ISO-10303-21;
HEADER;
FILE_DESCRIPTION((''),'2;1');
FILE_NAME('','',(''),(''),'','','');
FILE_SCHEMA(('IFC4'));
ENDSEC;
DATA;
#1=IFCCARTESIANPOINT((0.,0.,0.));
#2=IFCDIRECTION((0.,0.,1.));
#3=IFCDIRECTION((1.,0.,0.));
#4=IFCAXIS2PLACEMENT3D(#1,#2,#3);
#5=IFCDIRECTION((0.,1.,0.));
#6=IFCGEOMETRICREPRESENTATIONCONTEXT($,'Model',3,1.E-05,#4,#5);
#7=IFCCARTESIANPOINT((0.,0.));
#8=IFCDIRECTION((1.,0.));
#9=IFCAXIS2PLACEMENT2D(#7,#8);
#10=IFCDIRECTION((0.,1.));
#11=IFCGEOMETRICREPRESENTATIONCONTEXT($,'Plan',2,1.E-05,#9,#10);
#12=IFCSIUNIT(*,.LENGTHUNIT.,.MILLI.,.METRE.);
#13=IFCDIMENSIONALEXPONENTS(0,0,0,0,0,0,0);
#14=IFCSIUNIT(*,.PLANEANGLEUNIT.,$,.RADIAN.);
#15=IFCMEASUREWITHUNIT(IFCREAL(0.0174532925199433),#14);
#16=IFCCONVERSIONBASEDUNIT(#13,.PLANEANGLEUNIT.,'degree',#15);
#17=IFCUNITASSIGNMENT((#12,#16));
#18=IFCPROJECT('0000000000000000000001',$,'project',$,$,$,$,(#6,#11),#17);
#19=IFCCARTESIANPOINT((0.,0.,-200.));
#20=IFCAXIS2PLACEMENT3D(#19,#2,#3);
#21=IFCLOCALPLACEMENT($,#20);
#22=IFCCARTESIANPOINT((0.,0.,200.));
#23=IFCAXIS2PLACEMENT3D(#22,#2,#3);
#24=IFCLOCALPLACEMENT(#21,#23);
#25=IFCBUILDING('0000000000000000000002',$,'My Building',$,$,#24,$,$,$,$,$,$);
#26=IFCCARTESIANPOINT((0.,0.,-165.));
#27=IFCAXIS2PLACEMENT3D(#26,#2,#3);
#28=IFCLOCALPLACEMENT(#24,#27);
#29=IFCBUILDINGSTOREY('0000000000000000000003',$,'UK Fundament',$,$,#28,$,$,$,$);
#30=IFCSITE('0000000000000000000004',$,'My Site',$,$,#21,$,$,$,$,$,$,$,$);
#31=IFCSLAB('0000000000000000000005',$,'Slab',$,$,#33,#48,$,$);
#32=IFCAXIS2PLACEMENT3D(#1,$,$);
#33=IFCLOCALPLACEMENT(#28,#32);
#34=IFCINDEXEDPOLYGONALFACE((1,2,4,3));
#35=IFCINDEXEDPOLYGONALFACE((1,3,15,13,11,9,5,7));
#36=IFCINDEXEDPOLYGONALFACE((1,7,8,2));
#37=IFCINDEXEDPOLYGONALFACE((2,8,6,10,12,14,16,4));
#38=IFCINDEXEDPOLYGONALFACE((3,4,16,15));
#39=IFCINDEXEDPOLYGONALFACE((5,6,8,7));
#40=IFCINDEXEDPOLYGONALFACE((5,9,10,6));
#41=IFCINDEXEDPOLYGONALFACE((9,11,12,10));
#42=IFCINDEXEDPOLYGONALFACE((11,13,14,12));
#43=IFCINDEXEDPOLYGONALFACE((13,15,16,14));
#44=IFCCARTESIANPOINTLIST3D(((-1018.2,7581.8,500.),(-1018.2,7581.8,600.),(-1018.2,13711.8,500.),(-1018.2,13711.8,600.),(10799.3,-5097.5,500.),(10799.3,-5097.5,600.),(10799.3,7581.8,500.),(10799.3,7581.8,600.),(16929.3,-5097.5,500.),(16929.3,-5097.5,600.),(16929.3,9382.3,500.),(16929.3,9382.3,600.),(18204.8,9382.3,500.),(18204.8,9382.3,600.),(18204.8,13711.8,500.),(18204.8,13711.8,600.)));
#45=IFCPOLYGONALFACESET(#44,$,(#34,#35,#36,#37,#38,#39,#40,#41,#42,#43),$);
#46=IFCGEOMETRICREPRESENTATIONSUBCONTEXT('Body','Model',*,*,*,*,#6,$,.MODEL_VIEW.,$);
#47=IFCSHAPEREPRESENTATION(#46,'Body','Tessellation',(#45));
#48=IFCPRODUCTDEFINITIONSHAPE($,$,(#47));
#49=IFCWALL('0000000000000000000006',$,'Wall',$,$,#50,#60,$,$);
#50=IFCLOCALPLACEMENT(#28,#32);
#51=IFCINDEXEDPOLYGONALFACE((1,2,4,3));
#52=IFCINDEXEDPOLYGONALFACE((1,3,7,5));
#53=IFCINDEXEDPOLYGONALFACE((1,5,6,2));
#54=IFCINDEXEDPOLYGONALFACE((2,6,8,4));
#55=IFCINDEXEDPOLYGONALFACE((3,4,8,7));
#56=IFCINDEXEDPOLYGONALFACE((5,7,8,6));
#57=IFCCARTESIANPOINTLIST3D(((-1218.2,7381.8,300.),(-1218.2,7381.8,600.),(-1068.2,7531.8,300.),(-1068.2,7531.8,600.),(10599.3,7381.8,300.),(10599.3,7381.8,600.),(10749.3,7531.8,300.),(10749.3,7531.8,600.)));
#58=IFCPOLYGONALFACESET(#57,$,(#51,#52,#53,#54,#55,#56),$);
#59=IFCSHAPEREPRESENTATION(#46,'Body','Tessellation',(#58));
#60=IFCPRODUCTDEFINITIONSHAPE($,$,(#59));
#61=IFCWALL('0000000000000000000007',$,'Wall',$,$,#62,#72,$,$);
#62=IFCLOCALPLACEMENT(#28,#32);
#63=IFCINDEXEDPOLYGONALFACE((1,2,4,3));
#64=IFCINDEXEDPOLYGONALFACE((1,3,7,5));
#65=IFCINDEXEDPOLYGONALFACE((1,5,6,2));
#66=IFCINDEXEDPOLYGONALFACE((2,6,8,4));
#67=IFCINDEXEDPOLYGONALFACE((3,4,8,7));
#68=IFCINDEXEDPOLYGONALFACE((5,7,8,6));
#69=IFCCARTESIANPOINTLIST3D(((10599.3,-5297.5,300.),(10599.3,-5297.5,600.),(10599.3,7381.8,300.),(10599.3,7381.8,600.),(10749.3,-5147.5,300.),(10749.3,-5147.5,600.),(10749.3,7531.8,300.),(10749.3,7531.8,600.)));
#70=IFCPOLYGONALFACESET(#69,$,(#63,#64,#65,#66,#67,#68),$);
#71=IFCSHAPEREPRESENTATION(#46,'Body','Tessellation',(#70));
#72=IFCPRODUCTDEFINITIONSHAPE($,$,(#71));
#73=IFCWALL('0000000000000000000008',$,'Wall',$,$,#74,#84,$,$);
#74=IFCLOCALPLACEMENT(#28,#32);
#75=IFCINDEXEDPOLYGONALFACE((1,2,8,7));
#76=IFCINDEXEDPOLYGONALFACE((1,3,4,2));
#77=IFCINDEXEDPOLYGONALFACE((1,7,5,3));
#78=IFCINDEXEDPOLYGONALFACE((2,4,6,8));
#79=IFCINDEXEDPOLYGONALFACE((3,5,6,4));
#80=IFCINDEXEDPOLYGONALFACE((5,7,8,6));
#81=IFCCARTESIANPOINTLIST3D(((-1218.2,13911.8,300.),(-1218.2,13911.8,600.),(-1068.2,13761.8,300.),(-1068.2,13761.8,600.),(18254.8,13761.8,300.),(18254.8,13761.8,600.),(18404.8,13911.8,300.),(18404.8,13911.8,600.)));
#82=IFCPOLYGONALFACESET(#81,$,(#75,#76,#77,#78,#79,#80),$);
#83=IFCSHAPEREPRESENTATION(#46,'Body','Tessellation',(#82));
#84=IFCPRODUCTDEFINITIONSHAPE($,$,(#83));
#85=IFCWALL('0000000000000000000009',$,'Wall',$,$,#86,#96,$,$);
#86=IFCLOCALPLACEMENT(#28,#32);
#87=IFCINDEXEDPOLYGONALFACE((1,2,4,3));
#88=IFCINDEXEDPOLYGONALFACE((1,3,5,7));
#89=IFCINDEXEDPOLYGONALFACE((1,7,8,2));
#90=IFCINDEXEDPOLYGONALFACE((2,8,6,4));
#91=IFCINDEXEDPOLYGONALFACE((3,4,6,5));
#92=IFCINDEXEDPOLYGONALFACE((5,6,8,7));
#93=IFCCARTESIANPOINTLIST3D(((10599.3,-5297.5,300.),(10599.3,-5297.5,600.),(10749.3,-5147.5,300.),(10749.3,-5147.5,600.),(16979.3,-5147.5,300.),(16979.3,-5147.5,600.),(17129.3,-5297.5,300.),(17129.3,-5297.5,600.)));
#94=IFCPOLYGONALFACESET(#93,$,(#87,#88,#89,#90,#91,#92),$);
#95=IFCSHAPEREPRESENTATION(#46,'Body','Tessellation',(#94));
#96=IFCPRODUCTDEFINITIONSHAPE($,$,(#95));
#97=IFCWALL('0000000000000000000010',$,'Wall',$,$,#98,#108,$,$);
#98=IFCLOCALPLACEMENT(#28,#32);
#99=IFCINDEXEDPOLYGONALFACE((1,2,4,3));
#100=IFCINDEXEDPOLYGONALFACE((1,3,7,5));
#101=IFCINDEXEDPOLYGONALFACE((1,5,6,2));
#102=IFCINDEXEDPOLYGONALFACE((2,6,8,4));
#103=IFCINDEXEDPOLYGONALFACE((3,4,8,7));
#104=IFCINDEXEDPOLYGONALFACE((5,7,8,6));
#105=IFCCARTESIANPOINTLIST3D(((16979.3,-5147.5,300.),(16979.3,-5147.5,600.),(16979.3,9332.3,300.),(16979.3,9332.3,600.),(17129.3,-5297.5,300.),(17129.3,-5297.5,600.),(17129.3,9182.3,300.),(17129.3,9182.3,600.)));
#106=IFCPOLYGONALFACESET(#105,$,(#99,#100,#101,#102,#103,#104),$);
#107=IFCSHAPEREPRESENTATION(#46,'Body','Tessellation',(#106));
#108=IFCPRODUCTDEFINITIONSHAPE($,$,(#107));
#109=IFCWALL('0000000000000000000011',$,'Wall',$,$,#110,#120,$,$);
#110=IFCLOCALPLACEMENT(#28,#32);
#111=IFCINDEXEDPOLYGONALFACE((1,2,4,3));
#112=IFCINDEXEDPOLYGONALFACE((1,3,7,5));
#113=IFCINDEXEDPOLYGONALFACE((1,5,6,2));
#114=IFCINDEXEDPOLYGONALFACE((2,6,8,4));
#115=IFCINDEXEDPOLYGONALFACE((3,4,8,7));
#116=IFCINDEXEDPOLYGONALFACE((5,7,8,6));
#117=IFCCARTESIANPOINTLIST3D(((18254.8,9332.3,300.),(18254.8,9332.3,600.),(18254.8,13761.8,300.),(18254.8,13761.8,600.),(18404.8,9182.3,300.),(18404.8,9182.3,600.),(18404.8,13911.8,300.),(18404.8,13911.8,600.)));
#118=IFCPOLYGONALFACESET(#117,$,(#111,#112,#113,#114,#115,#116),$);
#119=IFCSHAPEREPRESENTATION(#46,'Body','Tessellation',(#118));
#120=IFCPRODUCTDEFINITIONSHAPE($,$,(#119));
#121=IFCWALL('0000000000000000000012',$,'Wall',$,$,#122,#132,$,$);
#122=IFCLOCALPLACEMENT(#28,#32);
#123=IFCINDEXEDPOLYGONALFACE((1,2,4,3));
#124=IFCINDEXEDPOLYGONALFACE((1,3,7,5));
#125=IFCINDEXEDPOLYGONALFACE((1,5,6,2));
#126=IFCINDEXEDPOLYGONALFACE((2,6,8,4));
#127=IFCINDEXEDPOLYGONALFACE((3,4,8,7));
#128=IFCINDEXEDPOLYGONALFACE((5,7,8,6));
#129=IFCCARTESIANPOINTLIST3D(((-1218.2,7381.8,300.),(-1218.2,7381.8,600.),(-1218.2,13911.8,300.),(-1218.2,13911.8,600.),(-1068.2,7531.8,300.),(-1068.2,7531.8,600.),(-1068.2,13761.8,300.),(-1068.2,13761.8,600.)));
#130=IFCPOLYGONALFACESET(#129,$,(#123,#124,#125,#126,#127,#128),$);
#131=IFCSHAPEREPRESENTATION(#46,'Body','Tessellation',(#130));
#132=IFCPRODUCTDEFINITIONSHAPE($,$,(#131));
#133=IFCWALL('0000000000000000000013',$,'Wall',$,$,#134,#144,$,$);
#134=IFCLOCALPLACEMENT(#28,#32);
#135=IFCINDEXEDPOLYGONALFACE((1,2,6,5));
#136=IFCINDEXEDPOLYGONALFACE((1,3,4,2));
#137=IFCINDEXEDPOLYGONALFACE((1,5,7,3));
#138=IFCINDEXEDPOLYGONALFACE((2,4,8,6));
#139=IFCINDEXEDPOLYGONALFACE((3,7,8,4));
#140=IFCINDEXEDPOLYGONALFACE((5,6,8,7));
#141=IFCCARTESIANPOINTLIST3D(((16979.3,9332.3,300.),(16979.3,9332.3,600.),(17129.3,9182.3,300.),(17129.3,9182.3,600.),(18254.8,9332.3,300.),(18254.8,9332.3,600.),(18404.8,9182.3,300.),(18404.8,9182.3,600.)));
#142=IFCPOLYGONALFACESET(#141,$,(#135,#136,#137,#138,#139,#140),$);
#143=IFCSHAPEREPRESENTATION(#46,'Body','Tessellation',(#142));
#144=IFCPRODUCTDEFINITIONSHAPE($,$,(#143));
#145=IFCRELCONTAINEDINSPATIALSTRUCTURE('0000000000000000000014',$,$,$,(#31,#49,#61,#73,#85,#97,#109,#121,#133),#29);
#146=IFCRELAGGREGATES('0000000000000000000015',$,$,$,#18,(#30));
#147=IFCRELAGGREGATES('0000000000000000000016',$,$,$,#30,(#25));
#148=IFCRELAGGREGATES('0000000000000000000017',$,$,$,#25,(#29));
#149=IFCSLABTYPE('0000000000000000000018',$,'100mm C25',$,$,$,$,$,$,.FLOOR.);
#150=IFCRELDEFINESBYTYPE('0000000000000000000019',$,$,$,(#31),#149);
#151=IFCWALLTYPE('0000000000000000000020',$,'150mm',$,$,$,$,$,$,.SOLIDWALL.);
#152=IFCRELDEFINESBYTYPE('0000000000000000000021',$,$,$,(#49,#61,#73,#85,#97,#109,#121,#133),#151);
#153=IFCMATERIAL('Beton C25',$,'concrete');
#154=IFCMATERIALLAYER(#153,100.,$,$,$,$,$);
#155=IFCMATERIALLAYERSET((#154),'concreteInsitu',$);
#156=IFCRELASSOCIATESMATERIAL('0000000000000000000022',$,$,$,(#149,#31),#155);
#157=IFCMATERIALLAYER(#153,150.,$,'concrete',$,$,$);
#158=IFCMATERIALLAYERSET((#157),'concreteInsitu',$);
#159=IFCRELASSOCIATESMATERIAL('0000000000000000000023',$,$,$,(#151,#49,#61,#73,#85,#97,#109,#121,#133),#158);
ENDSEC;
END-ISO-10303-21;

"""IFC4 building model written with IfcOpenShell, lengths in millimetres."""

from ifc_helpers import new_model, entity, si_unit, converted_unit, direction, frame, origin_with_axes, origin_2d_with_axis, place, context, subcontext, project, spatial, line, indexed_curve, outline, extrude, clip, halfspace, material, layer, layer_set, layer_usage, type_object, element, save


model = new_model("IFC4")

# Units and contexts
model_context = context("Model", 3, precision=1e-05, world=origin_with_axes(), true_north=direction((0.0, 1.0, 0.0)))
plan_context = context("Plan", 2, precision=1e-05, world=origin_2d_with_axis(), true_north=direction((0.0, 1.0)))
body_context = subcontext(model_context, "Body", "Model", "MODEL_VIEW")
ifc_project = project(units=[si_unit("LENGTHUNIT", "METRE", prefix="MILLI"), converted_unit("PLANEANGLEUNIT", "degree", entity("IfcReal", 0.0174532925199433), si_unit("PLANEANGLEUNIT", "RADIAN"), dimensions=[0, 0, 0, 0, 0, 0, 0])], contexts=[model_context, plan_context])

# Site, building, storey
site_placement = place(None, frame((0.0, 0.0, -200.0), z_axis=(0.0, 0.0, 1.0), x_axis=(1.0, 0.0, 0.0)))
site = spatial("IfcSite", under=ifc_project, at=site_placement, Name="My Site")
building_placement = place(site_placement, frame((0.0, 0.0, 200.0), z_axis=(0.0, 0.0, 1.0), x_axis=(1.0, 0.0, 0.0)))
building = spatial("IfcBuilding", under=site, at=building_placement, Name="My Building")
storey_placement = place(building_placement, frame((0.0, 0.0, -165.0), z_axis=(0.0, 0.0, 1.0), x_axis=(1.0, 0.0, 0.0)))
storey = spatial("IfcBuildingStorey", under=building, at=storey_placement, Name="UK Fundament")

# Slab
ifc_material = material(Name="Beton C25", Category="concrete")
ifc_layer_1 = layer(ifc_material, 100.0)
ifc_layer_set_1 = layer_set([ifc_layer_1], Name="concreteInsitu")
ifc_layer_usage_1 = layer_usage(ifc_layer_set_1, "AXIS3", "POSITIVE", 0.0)
slab_type = type_object("IfcSlabType", Name="100mm C25", PredefinedType="FLOOR", material=ifc_layer_set_1)
slab_placement = place(storey_placement, frame((-1018.2, 7581.8, 500.0), z_axis=(0.0, 0.0, 1.0), x_axis=(1.0, 0.0, 0.0)))
element("IfcSlab", 1, at=slab_placement, inside=storey, type_object=slab_type, material=ifc_layer_usage_1, Name="Slab", context=body_context, shape_type="SweptSolid", body=[
    extrude(outline(indexed_curve([(17947.4, 1800.5), (19222.9, 1800.5), (19222.9, 6130.0), (0.0, 6130.0), (0.0, 0.0), (11817.4, 0.0), (11817.4, -12679.3), (17947.4, -12679.3)], segments=[line(5, 4), line(4, 3), line(3, 2), line(2, 1), line(1, 8), line(8, 7), line(7, 6), line(6, 5)], self_intersect=False)), None, (0.0, 0.0, 1.0), 100.0),
])

# Walls
ifc_layer_2 = layer(ifc_material, 150.0, Name="concrete")
ifc_layer_set_2 = layer_set([ifc_layer_2], Name="concreteInsitu")
ifc_layer_usage_2 = layer_usage(ifc_layer_set_2, "AXIS2", "POSITIVE", 0.0)
wall_type = type_object("IfcWallType", Name="150mm", PredefinedType="SOLIDWALL", material=ifc_layer_set_2)
wall_1_placement = place(storey_placement, frame((-1218.2, 7381.8, 300.0), z_axis=(0.0, 0.0, 1.0), x_axis=(1.0, 0.0, 0.0)))
element("IfcWall", 2, at=wall_1_placement, inside=storey, type_object=wall_type, material=ifc_layer_usage_2, Name="Wall", context=body_context, shape_type="Clipping", body=[
    clip(clip(extrude(outline(indexed_curve([(0.0, 0.0), (0.0, 150.0), (11967.4, 150.0), (11967.4, 0.0), (0.0, 0.0)], self_intersect=False)), origin_with_axes(), (0.0, 0.0, 1.0), 300.0), halfspace(frame((0.0, 0.0, -135.0), z_axis=(-0.707107, 0.707107, 0.0), x_axis=(0.707107, 0.707107, 0.0)), False)), halfspace(frame((11817.4, 0.0, -135.0), z_axis=(0.707108, -0.707106, 0.0), x_axis=(-0.707106, -0.707108, 0.0)), False)),
])
ifc_layer_usage_3 = layer_usage(ifc_layer_set_2, "AXIS2", "POSITIVE", 0.0)
wall_2_placement = place(storey_placement, frame((10749.3, -5297.5, 300.0), z_axis=(0.0, 0.0, 1.0), x_axis=(0.0, 1.0, 0.0)))
element("IfcWall", 3, at=wall_2_placement, inside=storey, type_object=wall_type, material=ifc_layer_usage_3, Name="Wall", context=body_context, shape_type="Clipping", body=[
    clip(clip(extrude(outline(indexed_curve([(0.0, 0.0), (0.0, 150.0), (12829.3, 150.0), (12829.3, 0.0), (0.0, 0.0)], self_intersect=False)), origin_with_axes(), (0.0, 0.0, 1.0), 300.0), halfspace(frame((12829.3, 0.0, -135.0), z_axis=(0.707105, 0.707108, 0.0), x_axis=(0.707108, -0.707105, 0.0)), False)), halfspace(frame((150.0, 0.0, -135.0), z_axis=(-0.707105, -0.707108, 0.0), x_axis=(-0.707108, 0.707105, 0.0)), False)),
])
ifc_layer_usage_4 = layer_usage(ifc_layer_set_2, "AXIS2", "POSITIVE", 0.0)
wall_3_placement = place(storey_placement, frame((-1218.2, 13761.8, 300.0), z_axis=(0.0, 0.0, 1.0), x_axis=(1.0, 0.0, 0.0)))
element("IfcWall", 4, at=wall_3_placement, inside=storey, type_object=wall_type, material=ifc_layer_usage_4, Name="Wall", context=body_context, shape_type="Clipping", body=[
    clip(clip(extrude(outline(indexed_curve([(0.0, 0.0), (0.0, 150.0), (19622.9, 150.0), (19622.9, 0.0), (0.0, 0.0)], self_intersect=False)), origin_with_axes(), (0.0, 0.0, 1.0), 300.0), halfspace(frame((150.0, 0.0, 0.0), z_axis=(-0.707106, -0.707108, 0.0), x_axis=(-0.707108, 0.707106, 0.0)), False)), halfspace(frame((19472.9, 0.0, 0.0), z_axis=(0.707107, -0.707107, 0.0), x_axis=(-0.707107, -0.707107, 0.0)), False)),
])
ifc_layer_usage_5 = layer_usage(ifc_layer_set_2, "AXIS2", "POSITIVE", 0.0)
wall_4_placement = place(storey_placement, frame((10599.3, -5297.5, 300.0), z_axis=(0.0, 0.0, 1.0), x_axis=(1.0, 0.0, 0.0)))
element("IfcWall", 5, at=wall_4_placement, inside=storey, type_object=wall_type, material=ifc_layer_usage_5, Name="Wall", context=body_context, shape_type="Clipping", body=[
    clip(clip(extrude(outline(indexed_curve([(0.0, 0.0), (0.0, 150.0), (6530.0, 150.0), (6530.0, 0.0), (0.0, 0.0)], self_intersect=False)), origin_with_axes(), (0.0, 0.0, 1.0), 300.0), halfspace(frame((6530.0, 0.0, 0.0), z_axis=(0.707108, 0.707106, 0.0), x_axis=(0.707106, -0.707108, 0.0)), False)), halfspace(frame((0.0, 0.0, 0.0), z_axis=(-0.707108, 0.707106, 0.0), x_axis=(0.707106, 0.707108, 0.0)), False)),
])
ifc_layer_usage_6 = layer_usage(ifc_layer_set_2, "AXIS2", "POSITIVE", 0.0)
wall_5_placement = place(storey_placement, frame((17129.3, -5297.5, 300.0), z_axis=(0.0, 0.0, 1.0), x_axis=(0.0, 1.0, 0.0)))
element("IfcWall", 6, at=wall_5_placement, inside=storey, type_object=wall_type, material=ifc_layer_usage_6, Name="Wall", context=body_context, shape_type="Clipping", body=[
    clip(clip(extrude(outline(indexed_curve([(0.0, 0.0), (0.0, 150.0), (14629.8, 150.0), (14629.8, 0.0), (0.0, 0.0)], self_intersect=False)), origin_with_axes(), (0.0, 0.0, 1.0), 300.0), halfspace(frame((14479.8, 0.0, -135.0), z_axis=(0.707107, -0.707107, 0.0), x_axis=(-0.707107, -0.707107, 0.0)), False)), halfspace(frame((0.0, 0.0, -135.0), z_axis=(-0.707106, 0.707108, 0.0), x_axis=(0.707108, 0.707106, 0.0)), False)),
])
ifc_layer_usage_7 = layer_usage(ifc_layer_set_2, "AXIS2", "POSITIVE", 0.0)
wall_6_placement = place(storey_placement, frame((18404.8, 9182.3, 300.0), z_axis=(0.0, 0.0, 1.0), x_axis=(0.0, 1.0, 0.0)))
element("IfcWall", 7, at=wall_6_placement, inside=storey, type_object=wall_type, material=ifc_layer_usage_7, Name="Wall", context=body_context, shape_type="Clipping", body=[
    clip(clip(extrude(outline(indexed_curve([(0.0, 0.0), (0.0, 150.0), (4729.5, 150.0), (4729.5, 0.0), (0.0, 0.0)], self_intersect=False)), origin_with_axes(), (0.0, 0.0, 1.0), 300.0), halfspace(frame((0.0, 0.0, -135.0), z_axis=(-0.707107, 0.707107, 0.0), x_axis=(0.707107, 0.707107, 0.0)), False)), halfspace(frame((4729.5, 0.0, -135.0), z_axis=(0.707107, 0.707107, 0.0), x_axis=(0.707107, -0.707107, 0.0)), False)),
])
ifc_layer_usage_8 = layer_usage(ifc_layer_set_2, "AXIS2", "POSITIVE", 0.0)
wall_7_placement = place(storey_placement, frame((-1068.2, 7381.8, 300.0), z_axis=(0.0, 0.0, 1.0), x_axis=(0.0, 1.0, 0.0)))
element("IfcWall", 8, at=wall_7_placement, inside=storey, type_object=wall_type, material=ifc_layer_usage_8, Name="Wall", context=body_context, shape_type="Clipping", body=[
    clip(clip(extrude(outline(indexed_curve([(0.0, 0.0), (0.0, 150.0), (6530.0, 150.0), (6530.0, 0.0), (0.0, 0.0)], self_intersect=False)), origin_with_axes(), (0.0, 0.0, 1.0), 300.0), halfspace(frame((150.0, 0.0, -135.0), z_axis=(-0.707107, -0.707107, 0.0), x_axis=(-0.707107, 0.707107, 0.0)), False)), halfspace(frame((6380.0, 0.0, -135.0), z_axis=(0.707108, -0.707106, 0.0), x_axis=(-0.707106, -0.707108, 0.0)), False)),
])
ifc_layer_usage_9 = layer_usage(ifc_layer_set_2, "AXIS2", "POSITIVE", 0.0)
wall_8_placement = place(storey_placement, frame((16979.3, 9182.3, 300.0), z_axis=(0.0, 0.0, 1.0), x_axis=(1.0, 0.0, 0.0)))
element("IfcWall", 9, at=wall_8_placement, inside=storey, type_object=wall_type, material=ifc_layer_usage_9, Name="Wall", context=body_context, shape_type="Clipping", body=[
    clip(clip(extrude(outline(indexed_curve([(0.0, 0.0), (0.0, 150.0), (1425.5, 150.0), (1425.5, 0.0), (0.0, 0.0)], self_intersect=False)), origin_with_axes(), (0.0, 0.0, 1.0), 300.0), halfspace(frame((150.0, 0.0, -135.0), z_axis=(-0.707107, -0.707107, 0.0), x_axis=(-0.707107, 0.707107, 0.0)), False)), halfspace(frame((1425.5, 0.0, -135.0), z_axis=(0.707107, 0.707107, 0.0), x_axis=(0.707107, -0.707107, 0.0)), False)),
])

save(model, "model.ifc")
